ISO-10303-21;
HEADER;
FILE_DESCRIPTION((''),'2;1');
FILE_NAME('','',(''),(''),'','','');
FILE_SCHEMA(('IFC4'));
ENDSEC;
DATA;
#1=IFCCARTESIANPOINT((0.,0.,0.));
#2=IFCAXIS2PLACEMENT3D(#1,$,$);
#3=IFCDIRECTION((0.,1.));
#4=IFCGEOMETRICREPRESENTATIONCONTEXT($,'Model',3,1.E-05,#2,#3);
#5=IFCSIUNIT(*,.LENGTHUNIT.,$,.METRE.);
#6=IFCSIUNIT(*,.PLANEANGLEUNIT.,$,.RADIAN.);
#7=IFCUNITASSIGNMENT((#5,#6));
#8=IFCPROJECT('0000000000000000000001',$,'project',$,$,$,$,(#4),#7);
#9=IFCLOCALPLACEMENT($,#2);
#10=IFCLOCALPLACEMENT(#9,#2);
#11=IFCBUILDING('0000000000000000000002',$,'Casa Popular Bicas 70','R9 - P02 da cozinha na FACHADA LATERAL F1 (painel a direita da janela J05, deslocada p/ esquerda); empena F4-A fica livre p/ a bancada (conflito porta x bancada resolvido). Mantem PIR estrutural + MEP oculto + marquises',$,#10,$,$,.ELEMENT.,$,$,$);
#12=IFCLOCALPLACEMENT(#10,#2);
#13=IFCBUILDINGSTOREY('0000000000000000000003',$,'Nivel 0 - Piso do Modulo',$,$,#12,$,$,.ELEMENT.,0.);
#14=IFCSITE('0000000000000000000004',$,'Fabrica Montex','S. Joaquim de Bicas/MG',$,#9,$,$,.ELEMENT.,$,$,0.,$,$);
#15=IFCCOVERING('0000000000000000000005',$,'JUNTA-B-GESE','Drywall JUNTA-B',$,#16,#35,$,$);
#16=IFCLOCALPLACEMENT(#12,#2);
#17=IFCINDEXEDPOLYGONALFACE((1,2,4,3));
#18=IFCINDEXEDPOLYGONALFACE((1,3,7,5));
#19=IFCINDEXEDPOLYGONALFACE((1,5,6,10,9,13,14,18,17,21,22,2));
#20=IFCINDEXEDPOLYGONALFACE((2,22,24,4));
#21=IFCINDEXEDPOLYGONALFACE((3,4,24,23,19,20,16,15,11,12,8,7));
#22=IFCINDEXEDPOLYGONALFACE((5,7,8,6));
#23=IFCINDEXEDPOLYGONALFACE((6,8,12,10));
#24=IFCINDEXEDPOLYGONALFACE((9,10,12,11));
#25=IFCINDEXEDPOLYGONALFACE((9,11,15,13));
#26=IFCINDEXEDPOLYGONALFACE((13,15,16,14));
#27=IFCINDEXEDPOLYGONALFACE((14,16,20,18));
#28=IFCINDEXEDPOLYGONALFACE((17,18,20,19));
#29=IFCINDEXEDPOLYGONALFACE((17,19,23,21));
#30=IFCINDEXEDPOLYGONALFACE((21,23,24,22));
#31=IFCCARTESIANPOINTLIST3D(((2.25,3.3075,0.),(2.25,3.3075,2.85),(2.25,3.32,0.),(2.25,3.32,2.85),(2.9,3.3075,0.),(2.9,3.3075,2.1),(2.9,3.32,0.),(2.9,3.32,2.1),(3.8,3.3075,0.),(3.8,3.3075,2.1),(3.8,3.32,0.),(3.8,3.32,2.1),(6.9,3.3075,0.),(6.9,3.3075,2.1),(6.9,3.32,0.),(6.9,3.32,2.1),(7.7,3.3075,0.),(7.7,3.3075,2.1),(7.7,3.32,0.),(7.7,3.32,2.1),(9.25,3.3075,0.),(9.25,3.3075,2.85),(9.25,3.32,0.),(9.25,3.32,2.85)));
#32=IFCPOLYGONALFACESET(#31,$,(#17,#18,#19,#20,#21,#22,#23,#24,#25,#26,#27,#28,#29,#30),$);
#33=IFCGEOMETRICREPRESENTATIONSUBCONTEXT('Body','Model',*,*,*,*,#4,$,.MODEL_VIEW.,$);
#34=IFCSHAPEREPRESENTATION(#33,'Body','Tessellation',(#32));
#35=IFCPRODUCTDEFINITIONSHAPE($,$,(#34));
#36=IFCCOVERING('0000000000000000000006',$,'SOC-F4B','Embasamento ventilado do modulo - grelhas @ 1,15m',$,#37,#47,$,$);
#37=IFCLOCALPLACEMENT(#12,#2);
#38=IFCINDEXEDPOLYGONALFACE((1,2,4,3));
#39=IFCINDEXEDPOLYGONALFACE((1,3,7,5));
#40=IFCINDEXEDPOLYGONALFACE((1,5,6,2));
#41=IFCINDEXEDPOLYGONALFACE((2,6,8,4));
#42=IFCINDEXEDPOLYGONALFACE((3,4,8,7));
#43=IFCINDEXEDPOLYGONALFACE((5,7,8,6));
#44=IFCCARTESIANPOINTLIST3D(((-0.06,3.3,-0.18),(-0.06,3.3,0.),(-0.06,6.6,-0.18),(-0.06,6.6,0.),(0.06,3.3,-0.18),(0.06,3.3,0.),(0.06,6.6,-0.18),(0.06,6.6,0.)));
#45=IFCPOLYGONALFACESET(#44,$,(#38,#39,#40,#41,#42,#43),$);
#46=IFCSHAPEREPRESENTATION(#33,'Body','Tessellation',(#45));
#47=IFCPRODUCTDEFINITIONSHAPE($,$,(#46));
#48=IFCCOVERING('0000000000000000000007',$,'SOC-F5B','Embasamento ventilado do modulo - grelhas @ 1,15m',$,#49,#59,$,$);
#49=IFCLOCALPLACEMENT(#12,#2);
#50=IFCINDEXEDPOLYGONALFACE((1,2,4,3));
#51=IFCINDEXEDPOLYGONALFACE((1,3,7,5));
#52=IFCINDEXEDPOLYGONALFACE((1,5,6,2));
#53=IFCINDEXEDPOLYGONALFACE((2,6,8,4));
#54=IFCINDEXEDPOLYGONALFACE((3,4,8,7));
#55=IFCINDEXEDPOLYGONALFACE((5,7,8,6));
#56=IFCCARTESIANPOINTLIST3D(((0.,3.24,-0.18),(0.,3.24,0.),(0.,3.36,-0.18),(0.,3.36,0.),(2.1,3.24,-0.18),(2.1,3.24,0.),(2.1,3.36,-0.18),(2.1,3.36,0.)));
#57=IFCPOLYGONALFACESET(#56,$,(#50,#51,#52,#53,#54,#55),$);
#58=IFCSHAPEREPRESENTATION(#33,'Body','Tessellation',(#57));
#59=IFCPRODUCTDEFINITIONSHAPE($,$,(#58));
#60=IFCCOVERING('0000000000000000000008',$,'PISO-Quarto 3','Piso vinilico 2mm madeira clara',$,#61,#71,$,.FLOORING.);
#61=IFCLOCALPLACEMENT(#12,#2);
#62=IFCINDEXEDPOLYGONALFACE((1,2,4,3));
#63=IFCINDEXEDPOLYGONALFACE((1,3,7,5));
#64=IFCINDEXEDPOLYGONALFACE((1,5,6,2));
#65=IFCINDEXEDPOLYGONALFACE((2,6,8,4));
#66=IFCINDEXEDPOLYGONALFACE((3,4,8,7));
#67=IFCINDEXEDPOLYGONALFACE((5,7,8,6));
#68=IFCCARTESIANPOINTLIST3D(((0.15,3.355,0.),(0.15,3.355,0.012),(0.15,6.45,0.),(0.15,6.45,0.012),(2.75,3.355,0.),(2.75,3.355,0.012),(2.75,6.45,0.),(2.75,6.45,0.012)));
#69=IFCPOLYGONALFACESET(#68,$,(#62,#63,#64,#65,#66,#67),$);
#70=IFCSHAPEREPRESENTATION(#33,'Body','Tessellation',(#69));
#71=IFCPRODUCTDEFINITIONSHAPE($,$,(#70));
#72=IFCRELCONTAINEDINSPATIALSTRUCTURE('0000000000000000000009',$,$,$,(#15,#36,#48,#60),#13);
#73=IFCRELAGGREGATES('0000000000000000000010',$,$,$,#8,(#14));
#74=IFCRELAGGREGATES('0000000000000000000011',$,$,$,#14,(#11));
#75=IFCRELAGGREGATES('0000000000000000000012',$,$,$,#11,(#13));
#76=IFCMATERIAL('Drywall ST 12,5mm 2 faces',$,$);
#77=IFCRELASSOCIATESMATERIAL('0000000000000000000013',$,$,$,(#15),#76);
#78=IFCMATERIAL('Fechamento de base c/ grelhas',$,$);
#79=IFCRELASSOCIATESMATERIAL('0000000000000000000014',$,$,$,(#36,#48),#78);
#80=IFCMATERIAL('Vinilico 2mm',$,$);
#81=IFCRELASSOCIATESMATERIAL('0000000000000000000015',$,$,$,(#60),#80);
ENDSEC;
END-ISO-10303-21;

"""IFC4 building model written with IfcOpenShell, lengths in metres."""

from ifc_helpers import new_model, si_unit, direction, frame, frame_2d, origin, origin_2d, place, context, subcontext, project, spatial, rectangle, extrude, material, element, save


model = new_model("IFC4")

# Units and contexts
model_context = context("Model", 3, precision=1e-05, world=origin(), true_north=direction((0.0, 1.0)))
body_context = subcontext(model_context, "Body", "Model", "MODEL_VIEW")
ifc_project = project(units=[si_unit("LENGTHUNIT", "METRE"), si_unit("PLANEANGLEUNIT", "RADIAN")], contexts=[model_context])

# Site, building, storey
site_placement = place(None, origin())
site = spatial("IfcSite", under=ifc_project, at=site_placement, Name="Fabrica Montex", Description="S. Joaquim de Bicas/MG", CompositionType="ELEMENT", RefElevation=0.0)
building_placement = place(site_placement, origin())
building = spatial("IfcBuilding", under=site, at=building_placement, Name="Casa Popular Bicas 70", Description="R9 - P02 da cozinha na FACHADA LATERAL F1 (painel a direita da janela J05, deslocada p/ esquerda); empena F4-A fica livre p/ a bancada (conflito porta x bancada resolvido). Mantem PIR estrutural + MEP oculto + marquises", CompositionType="ELEMENT")
storey_placement = place(building_placement, origin())
storey = spatial("IfcBuildingStorey", under=building, at=storey_placement, Name="Nivel 0 - Piso do Modulo", CompositionType="ELEMENT", Elevation=0.0)

# Covering, openings
ifc_material_1 = material(Name="Drywall ST 12,5mm 2 faces")
covering_1_placement = place(storey_placement, frame((2.25, 3.3137, 0.0), x_axis=(1.0, 0.0, 0.0)))
covering_1 = element("IfcCovering", 1, at=covering_1_placement, inside=storey, material=ifc_material_1, Name="JUNTA-B-GESE", Description="Drywall JUNTA-B", context=body_context, shape_type="SweptSolid", body=[
    extrude(rectangle(XDim=7.0, YDim=0.0125, at=frame_2d((3.5, 0.0))), origin(), (0.0, 0.0, 1.0), 2.85),
])
opening_1_placement = place(storey_placement, frame((3.35, 3.3137, 0.0)))
element("IfcOpeningElement", 2, at=opening_1_placement, cuts=covering_1, PredefinedType="OPENING", context=body_context, shape_type="SweptSolid", body=[
    extrude(rectangle(XDim=0.9, YDim=0.0425, at=origin_2d()), origin(), (0.0, 0.0, 1.0), 2.1),
])
opening_2_placement = place(storey_placement, frame((7.3, 3.3137, 0.0)))
element("IfcOpeningElement", 3, at=opening_2_placement, cuts=covering_1, PredefinedType="OPENING", context=body_context, shape_type="SweptSolid", body=[
    extrude(rectangle(XDim=0.8, YDim=0.0425, at=origin_2d()), origin(), (0.0, 0.0, 1.0), 2.1),
])

# Coverings
ifc_material_2 = material(Name="Fechamento de base c/ grelhas")
covering_2_placement = place(storey_placement, frame((0.0, 3.3, -0.18), x_axis=(0.0, 1.0, 0.0)))
element("IfcCovering", 4, at=covering_2_placement, inside=storey, material=ifc_material_2, Name="SOC-F4B", Description="Embasamento ventilado do modulo - grelhas @ 1,15m", context=body_context, shape_type="SweptSolid", body=[
    extrude(rectangle(XDim=3.3, YDim=0.12, at=frame_2d((1.65, 0.0))), origin(), (0.0, 0.0, 1.0), 0.18),
])
covering_3_placement = place(storey_placement, frame((0.0, 3.3, -0.18), x_axis=(1.0, 0.0, 0.0)))
element("IfcCovering", 5, at=covering_3_placement, inside=storey, material=ifc_material_2, Name="SOC-F5B", Description="Embasamento ventilado do modulo - grelhas @ 1,15m", context=body_context, shape_type="SweptSolid", body=[
    extrude(rectangle(XDim=2.1, YDim=0.12, at=frame_2d((1.05, 0.0))), origin(), (0.0, 0.0, 1.0), 0.18),
])
ifc_material_3 = material(Name="Vinilico 2mm")
covering_4_placement = place(storey_placement, frame((0.15, 3.355, 0.0)))
element("IfcCovering", 6, at=covering_4_placement, inside=storey, material=ifc_material_3, Name="PISO-Quarto 3", Description="Piso vinilico 2mm madeira clara", PredefinedType="FLOORING", context=body_context, shape_type="SweptSolid", body=[
    extrude(rectangle(XDim=2.6, YDim=3.095, at=frame_2d((1.3, 1.5475))), origin(), (0.0, 0.0, 1.0), 0.012),
])

save(model, "model.ifc")
